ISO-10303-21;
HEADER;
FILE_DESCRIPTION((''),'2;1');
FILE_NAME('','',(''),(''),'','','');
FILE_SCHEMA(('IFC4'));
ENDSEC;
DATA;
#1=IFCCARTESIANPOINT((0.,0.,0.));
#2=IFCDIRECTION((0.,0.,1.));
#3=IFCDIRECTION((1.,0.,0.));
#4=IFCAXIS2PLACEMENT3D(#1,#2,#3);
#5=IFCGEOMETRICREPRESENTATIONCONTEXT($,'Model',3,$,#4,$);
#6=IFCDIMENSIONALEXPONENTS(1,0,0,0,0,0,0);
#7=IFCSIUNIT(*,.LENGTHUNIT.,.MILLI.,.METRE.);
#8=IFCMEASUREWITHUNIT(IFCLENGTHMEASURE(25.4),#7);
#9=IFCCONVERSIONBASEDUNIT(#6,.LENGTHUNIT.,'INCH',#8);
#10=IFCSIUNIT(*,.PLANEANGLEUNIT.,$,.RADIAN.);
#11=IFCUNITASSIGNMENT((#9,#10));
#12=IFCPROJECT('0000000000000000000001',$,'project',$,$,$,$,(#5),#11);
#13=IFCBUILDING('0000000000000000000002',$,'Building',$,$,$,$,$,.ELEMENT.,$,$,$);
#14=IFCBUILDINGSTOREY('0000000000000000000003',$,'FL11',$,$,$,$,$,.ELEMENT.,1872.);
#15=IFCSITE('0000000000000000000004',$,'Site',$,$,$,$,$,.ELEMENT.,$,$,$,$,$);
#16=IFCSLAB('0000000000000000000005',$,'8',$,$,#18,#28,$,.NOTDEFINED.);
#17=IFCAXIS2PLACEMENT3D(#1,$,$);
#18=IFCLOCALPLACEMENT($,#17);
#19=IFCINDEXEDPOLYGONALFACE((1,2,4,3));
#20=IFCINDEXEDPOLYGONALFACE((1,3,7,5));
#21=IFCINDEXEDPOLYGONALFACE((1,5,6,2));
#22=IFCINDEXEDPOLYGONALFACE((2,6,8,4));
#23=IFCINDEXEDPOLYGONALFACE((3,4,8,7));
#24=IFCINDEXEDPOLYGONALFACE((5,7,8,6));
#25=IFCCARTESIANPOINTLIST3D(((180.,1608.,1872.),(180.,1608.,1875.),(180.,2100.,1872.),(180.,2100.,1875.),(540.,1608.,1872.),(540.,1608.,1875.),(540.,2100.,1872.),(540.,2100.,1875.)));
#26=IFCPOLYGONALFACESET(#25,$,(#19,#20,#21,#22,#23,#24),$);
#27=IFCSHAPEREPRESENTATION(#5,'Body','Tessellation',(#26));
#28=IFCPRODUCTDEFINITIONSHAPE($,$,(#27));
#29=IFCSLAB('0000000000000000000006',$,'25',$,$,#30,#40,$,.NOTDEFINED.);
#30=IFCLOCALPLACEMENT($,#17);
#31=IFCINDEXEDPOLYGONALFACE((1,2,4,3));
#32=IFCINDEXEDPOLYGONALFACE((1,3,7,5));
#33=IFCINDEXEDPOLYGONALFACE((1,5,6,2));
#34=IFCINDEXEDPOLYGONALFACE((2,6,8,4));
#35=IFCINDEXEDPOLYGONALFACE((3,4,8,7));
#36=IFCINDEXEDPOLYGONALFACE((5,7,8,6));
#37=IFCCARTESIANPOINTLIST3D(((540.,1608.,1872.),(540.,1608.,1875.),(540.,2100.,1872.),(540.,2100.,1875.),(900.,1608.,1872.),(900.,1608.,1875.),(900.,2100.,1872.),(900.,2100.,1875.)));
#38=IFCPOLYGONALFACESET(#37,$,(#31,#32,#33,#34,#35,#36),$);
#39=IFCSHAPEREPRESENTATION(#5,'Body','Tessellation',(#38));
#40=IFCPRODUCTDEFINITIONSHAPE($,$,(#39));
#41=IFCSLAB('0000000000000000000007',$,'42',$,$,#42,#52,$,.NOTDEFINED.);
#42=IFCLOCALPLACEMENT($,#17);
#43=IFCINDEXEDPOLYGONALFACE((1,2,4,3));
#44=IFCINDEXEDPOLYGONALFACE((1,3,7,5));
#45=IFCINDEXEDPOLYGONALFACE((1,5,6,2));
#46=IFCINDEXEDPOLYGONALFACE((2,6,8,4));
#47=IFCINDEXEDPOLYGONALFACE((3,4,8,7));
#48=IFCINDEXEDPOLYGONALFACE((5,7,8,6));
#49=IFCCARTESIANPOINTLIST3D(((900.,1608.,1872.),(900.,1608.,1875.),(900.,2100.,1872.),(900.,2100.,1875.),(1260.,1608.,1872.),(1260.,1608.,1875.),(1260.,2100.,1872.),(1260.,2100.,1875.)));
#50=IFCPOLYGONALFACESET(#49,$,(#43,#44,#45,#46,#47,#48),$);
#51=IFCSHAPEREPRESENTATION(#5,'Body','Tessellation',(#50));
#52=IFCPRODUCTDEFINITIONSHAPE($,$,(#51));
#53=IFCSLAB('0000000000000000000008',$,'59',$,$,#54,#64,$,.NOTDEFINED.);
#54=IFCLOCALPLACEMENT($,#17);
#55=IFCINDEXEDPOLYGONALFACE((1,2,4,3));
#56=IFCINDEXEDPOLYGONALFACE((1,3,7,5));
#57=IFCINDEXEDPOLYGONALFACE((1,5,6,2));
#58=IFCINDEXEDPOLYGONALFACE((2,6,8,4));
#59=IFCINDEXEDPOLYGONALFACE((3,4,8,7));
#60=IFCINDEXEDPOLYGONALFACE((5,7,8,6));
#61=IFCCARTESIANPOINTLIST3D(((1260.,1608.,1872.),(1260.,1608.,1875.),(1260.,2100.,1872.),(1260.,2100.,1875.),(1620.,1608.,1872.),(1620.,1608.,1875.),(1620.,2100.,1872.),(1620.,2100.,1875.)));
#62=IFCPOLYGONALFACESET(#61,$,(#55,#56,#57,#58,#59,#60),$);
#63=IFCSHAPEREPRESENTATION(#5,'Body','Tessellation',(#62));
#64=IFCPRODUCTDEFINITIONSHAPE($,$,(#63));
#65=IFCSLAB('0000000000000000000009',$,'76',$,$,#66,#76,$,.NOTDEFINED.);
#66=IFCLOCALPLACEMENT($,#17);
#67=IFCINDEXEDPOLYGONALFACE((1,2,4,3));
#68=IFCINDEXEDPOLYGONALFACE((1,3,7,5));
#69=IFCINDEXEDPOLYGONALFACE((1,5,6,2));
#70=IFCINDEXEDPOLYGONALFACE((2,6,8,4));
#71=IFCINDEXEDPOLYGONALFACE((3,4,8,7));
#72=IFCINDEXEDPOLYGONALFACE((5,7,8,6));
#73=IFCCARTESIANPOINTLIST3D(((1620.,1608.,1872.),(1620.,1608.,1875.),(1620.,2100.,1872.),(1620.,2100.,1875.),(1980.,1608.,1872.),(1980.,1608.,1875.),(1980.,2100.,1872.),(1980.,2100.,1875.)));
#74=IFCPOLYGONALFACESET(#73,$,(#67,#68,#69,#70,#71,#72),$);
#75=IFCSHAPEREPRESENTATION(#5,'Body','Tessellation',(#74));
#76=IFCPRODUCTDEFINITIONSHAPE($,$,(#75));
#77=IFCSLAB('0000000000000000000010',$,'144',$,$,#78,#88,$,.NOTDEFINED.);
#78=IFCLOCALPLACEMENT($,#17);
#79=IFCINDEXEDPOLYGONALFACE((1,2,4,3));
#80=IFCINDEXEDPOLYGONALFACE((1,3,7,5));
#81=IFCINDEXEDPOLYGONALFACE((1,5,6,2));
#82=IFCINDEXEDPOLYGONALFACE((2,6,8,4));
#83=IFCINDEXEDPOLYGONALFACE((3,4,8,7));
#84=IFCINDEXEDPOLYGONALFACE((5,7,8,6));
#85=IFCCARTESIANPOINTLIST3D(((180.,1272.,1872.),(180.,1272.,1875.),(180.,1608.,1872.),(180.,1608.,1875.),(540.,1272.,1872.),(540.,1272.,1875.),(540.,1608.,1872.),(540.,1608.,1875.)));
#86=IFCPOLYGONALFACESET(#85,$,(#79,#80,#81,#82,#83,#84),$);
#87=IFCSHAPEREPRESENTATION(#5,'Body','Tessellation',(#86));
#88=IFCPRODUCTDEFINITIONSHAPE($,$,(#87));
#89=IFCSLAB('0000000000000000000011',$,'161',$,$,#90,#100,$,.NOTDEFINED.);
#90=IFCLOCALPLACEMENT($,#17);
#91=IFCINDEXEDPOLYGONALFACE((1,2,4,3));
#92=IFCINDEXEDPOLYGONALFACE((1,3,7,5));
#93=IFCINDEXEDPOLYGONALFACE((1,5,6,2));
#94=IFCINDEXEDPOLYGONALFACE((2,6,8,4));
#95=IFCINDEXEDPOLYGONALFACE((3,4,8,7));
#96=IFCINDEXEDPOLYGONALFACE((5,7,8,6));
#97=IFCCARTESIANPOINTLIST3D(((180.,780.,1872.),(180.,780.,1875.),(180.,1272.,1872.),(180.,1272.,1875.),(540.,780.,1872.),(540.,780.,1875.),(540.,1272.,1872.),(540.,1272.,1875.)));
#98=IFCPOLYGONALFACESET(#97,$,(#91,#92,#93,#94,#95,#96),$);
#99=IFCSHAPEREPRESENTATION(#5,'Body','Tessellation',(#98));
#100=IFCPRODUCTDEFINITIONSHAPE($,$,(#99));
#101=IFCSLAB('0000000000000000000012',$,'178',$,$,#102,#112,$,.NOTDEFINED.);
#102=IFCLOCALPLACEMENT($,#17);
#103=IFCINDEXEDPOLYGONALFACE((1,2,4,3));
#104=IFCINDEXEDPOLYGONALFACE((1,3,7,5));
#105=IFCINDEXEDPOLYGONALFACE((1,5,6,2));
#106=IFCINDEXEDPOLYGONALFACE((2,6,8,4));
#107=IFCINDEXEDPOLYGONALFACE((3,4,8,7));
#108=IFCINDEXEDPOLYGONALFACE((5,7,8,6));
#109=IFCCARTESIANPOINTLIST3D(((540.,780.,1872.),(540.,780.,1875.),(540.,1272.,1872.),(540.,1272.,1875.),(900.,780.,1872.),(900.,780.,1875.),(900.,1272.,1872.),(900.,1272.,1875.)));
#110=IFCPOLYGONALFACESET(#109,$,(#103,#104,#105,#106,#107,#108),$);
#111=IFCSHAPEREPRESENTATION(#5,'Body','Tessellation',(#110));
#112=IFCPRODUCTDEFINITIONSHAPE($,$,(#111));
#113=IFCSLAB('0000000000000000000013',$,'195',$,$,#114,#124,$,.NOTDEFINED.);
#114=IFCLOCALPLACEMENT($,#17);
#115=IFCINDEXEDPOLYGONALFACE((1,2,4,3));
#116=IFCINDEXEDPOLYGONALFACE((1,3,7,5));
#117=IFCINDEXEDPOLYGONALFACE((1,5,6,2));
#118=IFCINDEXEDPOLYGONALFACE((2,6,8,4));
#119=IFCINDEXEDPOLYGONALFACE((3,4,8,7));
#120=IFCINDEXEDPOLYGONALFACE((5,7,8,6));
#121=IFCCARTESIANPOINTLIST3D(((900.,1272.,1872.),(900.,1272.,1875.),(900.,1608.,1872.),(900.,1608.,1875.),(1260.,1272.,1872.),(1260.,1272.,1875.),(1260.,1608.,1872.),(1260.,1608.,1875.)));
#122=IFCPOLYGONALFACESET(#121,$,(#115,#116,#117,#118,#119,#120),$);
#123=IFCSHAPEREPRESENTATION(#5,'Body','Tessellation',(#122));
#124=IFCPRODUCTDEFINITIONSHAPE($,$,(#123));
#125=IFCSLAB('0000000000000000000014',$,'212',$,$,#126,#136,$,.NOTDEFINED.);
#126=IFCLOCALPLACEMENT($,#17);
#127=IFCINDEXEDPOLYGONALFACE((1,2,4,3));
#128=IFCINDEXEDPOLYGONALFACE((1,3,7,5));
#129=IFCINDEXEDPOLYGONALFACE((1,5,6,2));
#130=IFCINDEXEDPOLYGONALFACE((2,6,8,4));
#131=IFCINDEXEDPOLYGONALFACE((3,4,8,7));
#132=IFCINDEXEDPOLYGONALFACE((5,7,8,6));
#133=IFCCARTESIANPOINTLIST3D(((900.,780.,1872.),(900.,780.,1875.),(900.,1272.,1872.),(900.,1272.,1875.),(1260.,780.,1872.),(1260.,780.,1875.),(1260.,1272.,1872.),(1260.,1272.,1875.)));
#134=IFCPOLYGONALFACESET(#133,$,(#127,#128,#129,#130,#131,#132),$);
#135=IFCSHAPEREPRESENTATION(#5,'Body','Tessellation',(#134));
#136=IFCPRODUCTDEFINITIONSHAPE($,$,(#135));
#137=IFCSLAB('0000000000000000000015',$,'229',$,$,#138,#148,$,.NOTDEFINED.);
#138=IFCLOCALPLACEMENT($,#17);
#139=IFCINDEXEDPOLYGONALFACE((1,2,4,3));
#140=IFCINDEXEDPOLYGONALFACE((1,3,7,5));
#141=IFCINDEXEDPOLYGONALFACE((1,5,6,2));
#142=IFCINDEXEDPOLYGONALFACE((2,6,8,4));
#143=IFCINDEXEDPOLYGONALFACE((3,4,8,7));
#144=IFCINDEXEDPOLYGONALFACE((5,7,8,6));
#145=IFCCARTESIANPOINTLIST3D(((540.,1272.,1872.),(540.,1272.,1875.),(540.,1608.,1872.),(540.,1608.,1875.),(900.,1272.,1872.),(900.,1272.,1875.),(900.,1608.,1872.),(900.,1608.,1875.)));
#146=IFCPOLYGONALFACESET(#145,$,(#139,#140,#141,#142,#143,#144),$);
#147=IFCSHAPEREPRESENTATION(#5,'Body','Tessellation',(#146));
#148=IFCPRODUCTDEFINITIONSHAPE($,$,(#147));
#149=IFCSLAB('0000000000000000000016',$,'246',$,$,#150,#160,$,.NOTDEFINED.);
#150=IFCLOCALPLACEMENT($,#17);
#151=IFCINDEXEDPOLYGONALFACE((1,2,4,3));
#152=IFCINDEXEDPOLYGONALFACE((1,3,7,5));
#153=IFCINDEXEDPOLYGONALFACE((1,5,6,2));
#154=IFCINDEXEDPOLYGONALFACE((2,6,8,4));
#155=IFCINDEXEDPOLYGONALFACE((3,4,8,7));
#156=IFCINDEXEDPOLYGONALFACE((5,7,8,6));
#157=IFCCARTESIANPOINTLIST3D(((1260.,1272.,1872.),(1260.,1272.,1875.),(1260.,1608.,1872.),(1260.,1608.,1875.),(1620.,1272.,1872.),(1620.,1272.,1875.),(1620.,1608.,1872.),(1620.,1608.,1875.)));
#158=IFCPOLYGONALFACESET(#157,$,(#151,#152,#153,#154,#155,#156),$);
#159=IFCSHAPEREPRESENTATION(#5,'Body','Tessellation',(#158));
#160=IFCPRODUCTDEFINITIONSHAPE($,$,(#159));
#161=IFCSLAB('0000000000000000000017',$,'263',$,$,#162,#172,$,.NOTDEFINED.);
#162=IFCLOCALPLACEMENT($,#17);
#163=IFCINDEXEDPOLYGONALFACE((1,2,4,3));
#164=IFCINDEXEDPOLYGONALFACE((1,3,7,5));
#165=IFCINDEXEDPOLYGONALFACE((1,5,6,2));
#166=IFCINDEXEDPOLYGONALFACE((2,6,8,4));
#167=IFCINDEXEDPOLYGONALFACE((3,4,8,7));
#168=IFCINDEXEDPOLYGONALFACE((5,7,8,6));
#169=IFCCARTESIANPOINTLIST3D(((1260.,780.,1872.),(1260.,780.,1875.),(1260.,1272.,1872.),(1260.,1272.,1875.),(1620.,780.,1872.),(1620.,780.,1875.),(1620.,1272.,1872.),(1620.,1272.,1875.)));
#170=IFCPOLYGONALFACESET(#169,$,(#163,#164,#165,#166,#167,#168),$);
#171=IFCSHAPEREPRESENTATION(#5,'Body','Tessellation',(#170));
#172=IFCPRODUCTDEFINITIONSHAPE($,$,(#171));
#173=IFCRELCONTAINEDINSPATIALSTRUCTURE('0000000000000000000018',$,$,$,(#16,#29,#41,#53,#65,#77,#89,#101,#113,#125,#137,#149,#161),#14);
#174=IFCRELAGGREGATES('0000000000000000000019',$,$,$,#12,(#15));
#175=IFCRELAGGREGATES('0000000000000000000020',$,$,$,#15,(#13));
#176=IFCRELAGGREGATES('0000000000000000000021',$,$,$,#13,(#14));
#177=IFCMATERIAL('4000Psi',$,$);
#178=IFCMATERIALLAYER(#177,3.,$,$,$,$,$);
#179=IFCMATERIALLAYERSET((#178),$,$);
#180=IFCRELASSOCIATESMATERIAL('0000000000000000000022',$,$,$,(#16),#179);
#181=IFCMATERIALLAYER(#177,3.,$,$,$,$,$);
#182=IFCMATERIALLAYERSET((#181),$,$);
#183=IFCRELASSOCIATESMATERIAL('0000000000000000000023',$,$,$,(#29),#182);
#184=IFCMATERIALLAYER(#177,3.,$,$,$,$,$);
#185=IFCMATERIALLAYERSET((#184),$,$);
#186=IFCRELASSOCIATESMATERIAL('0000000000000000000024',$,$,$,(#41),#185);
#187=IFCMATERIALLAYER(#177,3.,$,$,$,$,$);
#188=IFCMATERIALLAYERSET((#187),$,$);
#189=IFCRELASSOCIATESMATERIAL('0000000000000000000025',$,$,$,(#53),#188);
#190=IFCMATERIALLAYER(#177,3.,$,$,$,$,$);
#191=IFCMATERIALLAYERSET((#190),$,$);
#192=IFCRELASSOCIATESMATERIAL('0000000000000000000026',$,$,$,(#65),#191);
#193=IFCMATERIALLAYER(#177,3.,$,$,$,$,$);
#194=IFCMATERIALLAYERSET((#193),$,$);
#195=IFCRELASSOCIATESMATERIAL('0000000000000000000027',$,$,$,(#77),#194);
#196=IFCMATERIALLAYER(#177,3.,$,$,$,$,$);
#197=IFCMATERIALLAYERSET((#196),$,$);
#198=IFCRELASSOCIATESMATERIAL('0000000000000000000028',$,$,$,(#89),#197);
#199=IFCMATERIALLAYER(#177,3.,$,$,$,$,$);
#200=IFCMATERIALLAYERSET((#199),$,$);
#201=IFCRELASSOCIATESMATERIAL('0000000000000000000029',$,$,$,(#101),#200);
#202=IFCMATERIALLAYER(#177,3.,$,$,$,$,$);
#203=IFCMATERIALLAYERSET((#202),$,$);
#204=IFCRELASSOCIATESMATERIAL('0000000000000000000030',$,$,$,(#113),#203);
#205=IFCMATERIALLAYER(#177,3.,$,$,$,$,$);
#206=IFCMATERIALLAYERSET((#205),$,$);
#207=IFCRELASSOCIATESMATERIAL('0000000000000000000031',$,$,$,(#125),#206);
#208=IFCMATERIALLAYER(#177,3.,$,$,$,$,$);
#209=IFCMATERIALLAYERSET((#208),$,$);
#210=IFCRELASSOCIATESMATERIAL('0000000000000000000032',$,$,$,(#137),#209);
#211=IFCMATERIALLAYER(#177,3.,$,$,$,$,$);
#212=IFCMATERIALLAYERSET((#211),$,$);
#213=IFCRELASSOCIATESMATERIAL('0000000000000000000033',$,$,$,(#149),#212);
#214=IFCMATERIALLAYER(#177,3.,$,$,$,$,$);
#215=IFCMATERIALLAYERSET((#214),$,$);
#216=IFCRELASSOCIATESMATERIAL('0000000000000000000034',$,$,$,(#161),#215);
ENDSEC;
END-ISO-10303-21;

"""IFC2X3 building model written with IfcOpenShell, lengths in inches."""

from ifc_helpers import new_model, entity, si_unit, converted_unit, frame, origin_with_axes, place, context, project, spatial, polyline, outline, extrude, material, layer, layer_set, layer_usage, element, save


model = new_model("IFC2X3")

# Units and contexts
model_context = context("Model", 3, world=origin_with_axes())
ifc_project = project(units=[converted_unit("LENGTHUNIT", "INCH", entity("IfcLengthMeasure", 25.4), si_unit("LENGTHUNIT", "METRE", prefix="MILLI"), dimensions=[1, 0, 0, 0, 0, 0, 0]), si_unit("PLANEANGLEUNIT", "RADIAN")], contexts=[model_context])

# Site, building, storey
site = spatial("IfcSite", under=ifc_project, Name="Site", CompositionType="ELEMENT")
building = spatial("IfcBuilding", under=site, Name="Building", CompositionType="ELEMENT")
storey = spatial("IfcBuildingStorey", under=building, Name="FL11", CompositionType="ELEMENT", Elevation=1872.0)

# Slabs
ifc_material_1 = material(Name="4000Psi")
ifc_layer_1 = layer(ifc_material_1, 3.0)
ifc_layer_set_1 = layer_set([ifc_layer_1])
ifc_layer_usage_1 = layer_usage(ifc_layer_set_1, "AXIS2", "POSITIVE", -3.0)
slab_1_placement = place(None, frame((180.0, 1608.0, 1872.0), z_axis=(0.0, 0.0, 1.0), x_axis=(1.0, 0.0, 0.0)))
element("IfcSlab", 1, at=slab_1_placement, inside=storey, material=ifc_layer_usage_1, Name="8", PredefinedType="NOTDEFINED", context=model_context, shape_type="SweptSolid", body=[
    extrude(outline(polyline([(0.0, 0.0), (360.0, 0.0), (360.0, 492.0), (0.0, 492.0), (0.0, 0.0)])), origin_with_axes(), (0.0, 0.0, 1.0), 3.0),
])
ifc_layer_2 = layer(ifc_material_1, 3.0)
ifc_layer_set_2 = layer_set([ifc_layer_2])
ifc_layer_usage_2 = layer_usage(ifc_layer_set_2, "AXIS2", "POSITIVE", -3.0)
slab_2_placement = place(None, frame((540.0, 1608.0, 1872.0), z_axis=(0.0, 0.0, 1.0), x_axis=(1.0, 0.0, 0.0)))
element("IfcSlab", 2, at=slab_2_placement, inside=storey, material=ifc_layer_usage_2, Name="25", PredefinedType="NOTDEFINED", context=model_context, shape_type="SweptSolid", body=[
    extrude(outline(polyline([(0.0, 0.0), (360.0, 0.0), (360.0, 492.0), (0.0, 492.0), (0.0, 0.0)])), origin_with_axes(), (0.0, 0.0, 1.0), 3.0),
])
ifc_layer_3 = layer(ifc_material_1, 3.0)
ifc_layer_set_3 = layer_set([ifc_layer_3])
ifc_layer_usage_3 = layer_usage(ifc_layer_set_3, "AXIS2", "POSITIVE", -3.0)
slab_3_placement = place(None, frame((900.0, 1608.0, 1872.0), z_axis=(0.0, 0.0, 1.0), x_axis=(1.0, 0.0, 0.0)))
element("IfcSlab", 3, at=slab_3_placement, inside=storey, material=ifc_layer_usage_3, Name="42", PredefinedType="NOTDEFINED", context=model_context, shape_type="SweptSolid", body=[
    extrude(outline(polyline([(0.0, 0.0), (360.0, 0.0), (360.0, 492.0), (0.0, 492.0), (0.0, 0.0)])), origin_with_axes(), (0.0, 0.0, 1.0), 3.0),
])
ifc_layer_4 = layer(ifc_material_1, 3.0)
ifc_layer_set_4 = layer_set([ifc_layer_4])
ifc_layer_usage_4 = layer_usage(ifc_layer_set_4, "AXIS2", "POSITIVE", -3.0)
slab_4_placement = place(None, frame((1260.0, 1608.0, 1872.0), z_axis=(0.0, 0.0, 1.0), x_axis=(1.0, 0.0, 0.0)))
element("IfcSlab", 4, at=slab_4_placement, inside=storey, material=ifc_layer_usage_4, Name="59", PredefinedType="NOTDEFINED", context=model_context, shape_type="SweptSolid", body=[
    extrude(outline(polyline([(0.0, 0.0), (360.0, 0.0), (360.0, 492.0), (0.0, 492.0), (0.0, 0.0)])), origin_with_axes(), (0.0, 0.0, 1.0), 3.0),
])
ifc_layer_5 = layer(ifc_material_1, 3.0)
ifc_layer_set_5 = layer_set([ifc_layer_5])
ifc_layer_usage_5 = layer_usage(ifc_layer_set_5, "AXIS2", "POSITIVE", -3.0)
slab_5_placement = place(None, frame((1620.0, 1608.0, 1872.0), z_axis=(0.0, 0.0, 1.0), x_axis=(1.0, 0.0, 0.0)))
element("IfcSlab", 5, at=slab_5_placement, inside=storey, material=ifc_layer_usage_5, Name="76", PredefinedType="NOTDEFINED", context=model_context, shape_type="SweptSolid", body=[
    extrude(outline(polyline([(0.0, 0.0), (360.0, 0.0), (360.0, 492.0), (0.0, 492.0), (0.0, 0.0)])), origin_with_axes(), (0.0, 0.0, 1.0), 3.0),
])
ifc_layer_6 = layer(ifc_material_1, 3.0)
ifc_layer_set_6 = layer_set([ifc_layer_6])
ifc_layer_usage_6 = layer_usage(ifc_layer_set_6, "AXIS2", "POSITIVE", -3.0)
slab_6_placement = place(None, frame((180.0, 1272.0, 1872.0), z_axis=(0.0, 0.0, 1.0), x_axis=(1.0, 0.0, 0.0)))
element("IfcSlab", 6, at=slab_6_placement, inside=storey, material=ifc_layer_usage_6, Name="144", PredefinedType="NOTDEFINED", context=model_context, shape_type="SweptSolid", body=[
    extrude(outline(polyline([(0.0, 0.0), (360.0, 0.0), (360.0, 336.0), (0.0, 336.0), (0.0, 0.0)])), origin_with_axes(), (0.0, 0.0, 1.0), 3.0),
])
ifc_layer_7 = layer(ifc_material_1, 3.0)
ifc_layer_set_7 = layer_set([ifc_layer_7])
ifc_layer_usage_7 = layer_usage(ifc_layer_set_7, "AXIS2", "POSITIVE", -3.0)
slab_7_placement = place(None, frame((180.0, 780.0, 1872.0), z_axis=(0.0, 0.0, 1.0), x_axis=(1.0, 0.0, 0.0)))
element("IfcSlab", 7, at=slab_7_placement, inside=storey, material=ifc_layer_usage_7, Name="161", PredefinedType="NOTDEFINED", context=model_context, shape_type="SweptSolid", body=[
    extrude(outline(polyline([(0.0, 0.0), (360.0, 0.0), (360.0, 492.0), (0.0, 492.0), (0.0, 0.0)])), origin_with_axes(), (0.0, 0.0, 1.0), 3.0),
])
ifc_layer_8 = layer(ifc_material_1, 3.0)
ifc_layer_set_8 = layer_set([ifc_layer_8])
ifc_layer_usage_8 = layer_usage(ifc_layer_set_8, "AXIS2", "POSITIVE", -3.0)
slab_8_placement = place(None, frame((540.0, 780.0, 1872.0), z_axis=(0.0, 0.0, 1.0), x_axis=(1.0, 0.0, 0.0)))
element("IfcSlab", 8, at=slab_8_placement, inside=storey, material=ifc_layer_usage_8, Name="178", PredefinedType="NOTDEFINED", context=model_context, shape_type="SweptSolid", body=[
    extrude(outline(polyline([(0.0, 0.0), (360.0, 0.0), (360.0, 492.0), (0.0, 492.0), (0.0, 0.0)])), origin_with_axes(), (0.0, 0.0, 1.0), 3.0),
])
ifc_layer_9 = layer(ifc_material_1, 3.0)
ifc_layer_set_9 = layer_set([ifc_layer_9])
ifc_layer_usage_9 = layer_usage(ifc_layer_set_9, "AXIS2", "POSITIVE", -3.0)
slab_9_placement = place(None, frame((900.0, 1272.0, 1872.0), z_axis=(0.0, 0.0, 1.0), x_axis=(1.0, 0.0, 0.0)))
element("IfcSlab", 9, at=slab_9_placement, inside=storey, material=ifc_layer_usage_9, Name="195", PredefinedType="NOTDEFINED", context=model_context, shape_type="SweptSolid", body=[
    extrude(outline(polyline([(0.0, 0.0), (360.0, 0.0), (360.0, 336.0), (0.0, 336.0), (0.0, 0.0)])), origin_with_axes(), (0.0, 0.0, 1.0), 3.0),
])
ifc_layer_10 = layer(ifc_material_1, 3.0)
ifc_layer_set_10 = layer_set([ifc_layer_10])
ifc_layer_usage_10 = layer_usage(ifc_layer_set_10, "AXIS2", "POSITIVE", -3.0)
slab_10_placement = place(None, frame((900.0, 780.0, 1872.0), z_axis=(0.0, 0.0, 1.0), x_axis=(1.0, 0.0, 0.0)))
element("IfcSlab", 10, at=slab_10_placement, inside=storey, material=ifc_layer_usage_10, Name="212", PredefinedType="NOTDEFINED", context=model_context, shape_type="SweptSolid", body=[
    extrude(outline(polyline([(0.0, 0.0), (360.0, 0.0), (360.0, 492.0), (0.0, 492.0), (0.0, 0.0)])), origin_with_axes(), (0.0, 0.0, 1.0), 3.0),
])
ifc_layer_11 = layer(ifc_material_1, 3.0)
ifc_layer_set_11 = layer_set([ifc_layer_11])
ifc_layer_usage_11 = layer_usage(ifc_layer_set_11, "AXIS2", "POSITIVE", -3.0)
slab_11_placement = place(None, frame((540.0, 1272.0, 1872.0), z_axis=(0.0, 0.0, 1.0), x_axis=(1.0, 0.0, 0.0)))
element("IfcSlab", 11, at=slab_11_placement, inside=storey, material=ifc_layer_usage_11, Name="229", PredefinedType="NOTDEFINED", context=model_context, shape_type="SweptSolid", body=[
    extrude(outline(polyline([(0.0, 0.0), (360.0, 0.0), (360.0, 336.0), (0.0, 336.0), (0.0, 0.0)])), origin_with_axes(), (0.0, 0.0, 1.0), 3.0),
])
ifc_layer_12 = layer(ifc_material_1, 3.0)
ifc_layer_set_12 = layer_set([ifc_layer_12])
ifc_layer_usage_12 = layer_usage(ifc_layer_set_12, "AXIS2", "POSITIVE", -3.0)
slab_12_placement = place(None, frame((1260.0, 1272.0, 1872.0), z_axis=(0.0, 0.0, 1.0), x_axis=(1.0, 0.0, 0.0)))
element("IfcSlab", 12, at=slab_12_placement, inside=storey, material=ifc_layer_usage_12, Name="246", PredefinedType="NOTDEFINED", context=model_context, shape_type="SweptSolid", body=[
    extrude(outline(polyline([(0.0, 0.0), (360.0, 0.0), (360.0, 336.0), (0.0, 336.0), (0.0, 0.0)])), origin_with_axes(), (0.0, 0.0, 1.0), 3.0),
])
ifc_layer_13 = layer(ifc_material_1, 3.0)
ifc_layer_set_13 = layer_set([ifc_layer_13])
ifc_layer_usage_13 = layer_usage(ifc_layer_set_13, "AXIS2", "POSITIVE", -3.0)
slab_13_placement = place(None, frame((1260.0, 780.0, 1872.0), z_axis=(0.0, 0.0, 1.0), x_axis=(1.0, 0.0, 0.0)))
element("IfcSlab", 13, at=slab_13_placement, inside=storey, material=ifc_layer_usage_13, Name="263", PredefinedType="NOTDEFINED", context=model_context, shape_type="SweptSolid", body=[
    extrude(outline(polyline([(0.0, 0.0), (360.0, 0.0), (360.0, 492.0), (0.0, 492.0), (0.0, 0.0)])), origin_with_axes(), (0.0, 0.0, 1.0), 3.0),
])

save(model, "model.ifc")
